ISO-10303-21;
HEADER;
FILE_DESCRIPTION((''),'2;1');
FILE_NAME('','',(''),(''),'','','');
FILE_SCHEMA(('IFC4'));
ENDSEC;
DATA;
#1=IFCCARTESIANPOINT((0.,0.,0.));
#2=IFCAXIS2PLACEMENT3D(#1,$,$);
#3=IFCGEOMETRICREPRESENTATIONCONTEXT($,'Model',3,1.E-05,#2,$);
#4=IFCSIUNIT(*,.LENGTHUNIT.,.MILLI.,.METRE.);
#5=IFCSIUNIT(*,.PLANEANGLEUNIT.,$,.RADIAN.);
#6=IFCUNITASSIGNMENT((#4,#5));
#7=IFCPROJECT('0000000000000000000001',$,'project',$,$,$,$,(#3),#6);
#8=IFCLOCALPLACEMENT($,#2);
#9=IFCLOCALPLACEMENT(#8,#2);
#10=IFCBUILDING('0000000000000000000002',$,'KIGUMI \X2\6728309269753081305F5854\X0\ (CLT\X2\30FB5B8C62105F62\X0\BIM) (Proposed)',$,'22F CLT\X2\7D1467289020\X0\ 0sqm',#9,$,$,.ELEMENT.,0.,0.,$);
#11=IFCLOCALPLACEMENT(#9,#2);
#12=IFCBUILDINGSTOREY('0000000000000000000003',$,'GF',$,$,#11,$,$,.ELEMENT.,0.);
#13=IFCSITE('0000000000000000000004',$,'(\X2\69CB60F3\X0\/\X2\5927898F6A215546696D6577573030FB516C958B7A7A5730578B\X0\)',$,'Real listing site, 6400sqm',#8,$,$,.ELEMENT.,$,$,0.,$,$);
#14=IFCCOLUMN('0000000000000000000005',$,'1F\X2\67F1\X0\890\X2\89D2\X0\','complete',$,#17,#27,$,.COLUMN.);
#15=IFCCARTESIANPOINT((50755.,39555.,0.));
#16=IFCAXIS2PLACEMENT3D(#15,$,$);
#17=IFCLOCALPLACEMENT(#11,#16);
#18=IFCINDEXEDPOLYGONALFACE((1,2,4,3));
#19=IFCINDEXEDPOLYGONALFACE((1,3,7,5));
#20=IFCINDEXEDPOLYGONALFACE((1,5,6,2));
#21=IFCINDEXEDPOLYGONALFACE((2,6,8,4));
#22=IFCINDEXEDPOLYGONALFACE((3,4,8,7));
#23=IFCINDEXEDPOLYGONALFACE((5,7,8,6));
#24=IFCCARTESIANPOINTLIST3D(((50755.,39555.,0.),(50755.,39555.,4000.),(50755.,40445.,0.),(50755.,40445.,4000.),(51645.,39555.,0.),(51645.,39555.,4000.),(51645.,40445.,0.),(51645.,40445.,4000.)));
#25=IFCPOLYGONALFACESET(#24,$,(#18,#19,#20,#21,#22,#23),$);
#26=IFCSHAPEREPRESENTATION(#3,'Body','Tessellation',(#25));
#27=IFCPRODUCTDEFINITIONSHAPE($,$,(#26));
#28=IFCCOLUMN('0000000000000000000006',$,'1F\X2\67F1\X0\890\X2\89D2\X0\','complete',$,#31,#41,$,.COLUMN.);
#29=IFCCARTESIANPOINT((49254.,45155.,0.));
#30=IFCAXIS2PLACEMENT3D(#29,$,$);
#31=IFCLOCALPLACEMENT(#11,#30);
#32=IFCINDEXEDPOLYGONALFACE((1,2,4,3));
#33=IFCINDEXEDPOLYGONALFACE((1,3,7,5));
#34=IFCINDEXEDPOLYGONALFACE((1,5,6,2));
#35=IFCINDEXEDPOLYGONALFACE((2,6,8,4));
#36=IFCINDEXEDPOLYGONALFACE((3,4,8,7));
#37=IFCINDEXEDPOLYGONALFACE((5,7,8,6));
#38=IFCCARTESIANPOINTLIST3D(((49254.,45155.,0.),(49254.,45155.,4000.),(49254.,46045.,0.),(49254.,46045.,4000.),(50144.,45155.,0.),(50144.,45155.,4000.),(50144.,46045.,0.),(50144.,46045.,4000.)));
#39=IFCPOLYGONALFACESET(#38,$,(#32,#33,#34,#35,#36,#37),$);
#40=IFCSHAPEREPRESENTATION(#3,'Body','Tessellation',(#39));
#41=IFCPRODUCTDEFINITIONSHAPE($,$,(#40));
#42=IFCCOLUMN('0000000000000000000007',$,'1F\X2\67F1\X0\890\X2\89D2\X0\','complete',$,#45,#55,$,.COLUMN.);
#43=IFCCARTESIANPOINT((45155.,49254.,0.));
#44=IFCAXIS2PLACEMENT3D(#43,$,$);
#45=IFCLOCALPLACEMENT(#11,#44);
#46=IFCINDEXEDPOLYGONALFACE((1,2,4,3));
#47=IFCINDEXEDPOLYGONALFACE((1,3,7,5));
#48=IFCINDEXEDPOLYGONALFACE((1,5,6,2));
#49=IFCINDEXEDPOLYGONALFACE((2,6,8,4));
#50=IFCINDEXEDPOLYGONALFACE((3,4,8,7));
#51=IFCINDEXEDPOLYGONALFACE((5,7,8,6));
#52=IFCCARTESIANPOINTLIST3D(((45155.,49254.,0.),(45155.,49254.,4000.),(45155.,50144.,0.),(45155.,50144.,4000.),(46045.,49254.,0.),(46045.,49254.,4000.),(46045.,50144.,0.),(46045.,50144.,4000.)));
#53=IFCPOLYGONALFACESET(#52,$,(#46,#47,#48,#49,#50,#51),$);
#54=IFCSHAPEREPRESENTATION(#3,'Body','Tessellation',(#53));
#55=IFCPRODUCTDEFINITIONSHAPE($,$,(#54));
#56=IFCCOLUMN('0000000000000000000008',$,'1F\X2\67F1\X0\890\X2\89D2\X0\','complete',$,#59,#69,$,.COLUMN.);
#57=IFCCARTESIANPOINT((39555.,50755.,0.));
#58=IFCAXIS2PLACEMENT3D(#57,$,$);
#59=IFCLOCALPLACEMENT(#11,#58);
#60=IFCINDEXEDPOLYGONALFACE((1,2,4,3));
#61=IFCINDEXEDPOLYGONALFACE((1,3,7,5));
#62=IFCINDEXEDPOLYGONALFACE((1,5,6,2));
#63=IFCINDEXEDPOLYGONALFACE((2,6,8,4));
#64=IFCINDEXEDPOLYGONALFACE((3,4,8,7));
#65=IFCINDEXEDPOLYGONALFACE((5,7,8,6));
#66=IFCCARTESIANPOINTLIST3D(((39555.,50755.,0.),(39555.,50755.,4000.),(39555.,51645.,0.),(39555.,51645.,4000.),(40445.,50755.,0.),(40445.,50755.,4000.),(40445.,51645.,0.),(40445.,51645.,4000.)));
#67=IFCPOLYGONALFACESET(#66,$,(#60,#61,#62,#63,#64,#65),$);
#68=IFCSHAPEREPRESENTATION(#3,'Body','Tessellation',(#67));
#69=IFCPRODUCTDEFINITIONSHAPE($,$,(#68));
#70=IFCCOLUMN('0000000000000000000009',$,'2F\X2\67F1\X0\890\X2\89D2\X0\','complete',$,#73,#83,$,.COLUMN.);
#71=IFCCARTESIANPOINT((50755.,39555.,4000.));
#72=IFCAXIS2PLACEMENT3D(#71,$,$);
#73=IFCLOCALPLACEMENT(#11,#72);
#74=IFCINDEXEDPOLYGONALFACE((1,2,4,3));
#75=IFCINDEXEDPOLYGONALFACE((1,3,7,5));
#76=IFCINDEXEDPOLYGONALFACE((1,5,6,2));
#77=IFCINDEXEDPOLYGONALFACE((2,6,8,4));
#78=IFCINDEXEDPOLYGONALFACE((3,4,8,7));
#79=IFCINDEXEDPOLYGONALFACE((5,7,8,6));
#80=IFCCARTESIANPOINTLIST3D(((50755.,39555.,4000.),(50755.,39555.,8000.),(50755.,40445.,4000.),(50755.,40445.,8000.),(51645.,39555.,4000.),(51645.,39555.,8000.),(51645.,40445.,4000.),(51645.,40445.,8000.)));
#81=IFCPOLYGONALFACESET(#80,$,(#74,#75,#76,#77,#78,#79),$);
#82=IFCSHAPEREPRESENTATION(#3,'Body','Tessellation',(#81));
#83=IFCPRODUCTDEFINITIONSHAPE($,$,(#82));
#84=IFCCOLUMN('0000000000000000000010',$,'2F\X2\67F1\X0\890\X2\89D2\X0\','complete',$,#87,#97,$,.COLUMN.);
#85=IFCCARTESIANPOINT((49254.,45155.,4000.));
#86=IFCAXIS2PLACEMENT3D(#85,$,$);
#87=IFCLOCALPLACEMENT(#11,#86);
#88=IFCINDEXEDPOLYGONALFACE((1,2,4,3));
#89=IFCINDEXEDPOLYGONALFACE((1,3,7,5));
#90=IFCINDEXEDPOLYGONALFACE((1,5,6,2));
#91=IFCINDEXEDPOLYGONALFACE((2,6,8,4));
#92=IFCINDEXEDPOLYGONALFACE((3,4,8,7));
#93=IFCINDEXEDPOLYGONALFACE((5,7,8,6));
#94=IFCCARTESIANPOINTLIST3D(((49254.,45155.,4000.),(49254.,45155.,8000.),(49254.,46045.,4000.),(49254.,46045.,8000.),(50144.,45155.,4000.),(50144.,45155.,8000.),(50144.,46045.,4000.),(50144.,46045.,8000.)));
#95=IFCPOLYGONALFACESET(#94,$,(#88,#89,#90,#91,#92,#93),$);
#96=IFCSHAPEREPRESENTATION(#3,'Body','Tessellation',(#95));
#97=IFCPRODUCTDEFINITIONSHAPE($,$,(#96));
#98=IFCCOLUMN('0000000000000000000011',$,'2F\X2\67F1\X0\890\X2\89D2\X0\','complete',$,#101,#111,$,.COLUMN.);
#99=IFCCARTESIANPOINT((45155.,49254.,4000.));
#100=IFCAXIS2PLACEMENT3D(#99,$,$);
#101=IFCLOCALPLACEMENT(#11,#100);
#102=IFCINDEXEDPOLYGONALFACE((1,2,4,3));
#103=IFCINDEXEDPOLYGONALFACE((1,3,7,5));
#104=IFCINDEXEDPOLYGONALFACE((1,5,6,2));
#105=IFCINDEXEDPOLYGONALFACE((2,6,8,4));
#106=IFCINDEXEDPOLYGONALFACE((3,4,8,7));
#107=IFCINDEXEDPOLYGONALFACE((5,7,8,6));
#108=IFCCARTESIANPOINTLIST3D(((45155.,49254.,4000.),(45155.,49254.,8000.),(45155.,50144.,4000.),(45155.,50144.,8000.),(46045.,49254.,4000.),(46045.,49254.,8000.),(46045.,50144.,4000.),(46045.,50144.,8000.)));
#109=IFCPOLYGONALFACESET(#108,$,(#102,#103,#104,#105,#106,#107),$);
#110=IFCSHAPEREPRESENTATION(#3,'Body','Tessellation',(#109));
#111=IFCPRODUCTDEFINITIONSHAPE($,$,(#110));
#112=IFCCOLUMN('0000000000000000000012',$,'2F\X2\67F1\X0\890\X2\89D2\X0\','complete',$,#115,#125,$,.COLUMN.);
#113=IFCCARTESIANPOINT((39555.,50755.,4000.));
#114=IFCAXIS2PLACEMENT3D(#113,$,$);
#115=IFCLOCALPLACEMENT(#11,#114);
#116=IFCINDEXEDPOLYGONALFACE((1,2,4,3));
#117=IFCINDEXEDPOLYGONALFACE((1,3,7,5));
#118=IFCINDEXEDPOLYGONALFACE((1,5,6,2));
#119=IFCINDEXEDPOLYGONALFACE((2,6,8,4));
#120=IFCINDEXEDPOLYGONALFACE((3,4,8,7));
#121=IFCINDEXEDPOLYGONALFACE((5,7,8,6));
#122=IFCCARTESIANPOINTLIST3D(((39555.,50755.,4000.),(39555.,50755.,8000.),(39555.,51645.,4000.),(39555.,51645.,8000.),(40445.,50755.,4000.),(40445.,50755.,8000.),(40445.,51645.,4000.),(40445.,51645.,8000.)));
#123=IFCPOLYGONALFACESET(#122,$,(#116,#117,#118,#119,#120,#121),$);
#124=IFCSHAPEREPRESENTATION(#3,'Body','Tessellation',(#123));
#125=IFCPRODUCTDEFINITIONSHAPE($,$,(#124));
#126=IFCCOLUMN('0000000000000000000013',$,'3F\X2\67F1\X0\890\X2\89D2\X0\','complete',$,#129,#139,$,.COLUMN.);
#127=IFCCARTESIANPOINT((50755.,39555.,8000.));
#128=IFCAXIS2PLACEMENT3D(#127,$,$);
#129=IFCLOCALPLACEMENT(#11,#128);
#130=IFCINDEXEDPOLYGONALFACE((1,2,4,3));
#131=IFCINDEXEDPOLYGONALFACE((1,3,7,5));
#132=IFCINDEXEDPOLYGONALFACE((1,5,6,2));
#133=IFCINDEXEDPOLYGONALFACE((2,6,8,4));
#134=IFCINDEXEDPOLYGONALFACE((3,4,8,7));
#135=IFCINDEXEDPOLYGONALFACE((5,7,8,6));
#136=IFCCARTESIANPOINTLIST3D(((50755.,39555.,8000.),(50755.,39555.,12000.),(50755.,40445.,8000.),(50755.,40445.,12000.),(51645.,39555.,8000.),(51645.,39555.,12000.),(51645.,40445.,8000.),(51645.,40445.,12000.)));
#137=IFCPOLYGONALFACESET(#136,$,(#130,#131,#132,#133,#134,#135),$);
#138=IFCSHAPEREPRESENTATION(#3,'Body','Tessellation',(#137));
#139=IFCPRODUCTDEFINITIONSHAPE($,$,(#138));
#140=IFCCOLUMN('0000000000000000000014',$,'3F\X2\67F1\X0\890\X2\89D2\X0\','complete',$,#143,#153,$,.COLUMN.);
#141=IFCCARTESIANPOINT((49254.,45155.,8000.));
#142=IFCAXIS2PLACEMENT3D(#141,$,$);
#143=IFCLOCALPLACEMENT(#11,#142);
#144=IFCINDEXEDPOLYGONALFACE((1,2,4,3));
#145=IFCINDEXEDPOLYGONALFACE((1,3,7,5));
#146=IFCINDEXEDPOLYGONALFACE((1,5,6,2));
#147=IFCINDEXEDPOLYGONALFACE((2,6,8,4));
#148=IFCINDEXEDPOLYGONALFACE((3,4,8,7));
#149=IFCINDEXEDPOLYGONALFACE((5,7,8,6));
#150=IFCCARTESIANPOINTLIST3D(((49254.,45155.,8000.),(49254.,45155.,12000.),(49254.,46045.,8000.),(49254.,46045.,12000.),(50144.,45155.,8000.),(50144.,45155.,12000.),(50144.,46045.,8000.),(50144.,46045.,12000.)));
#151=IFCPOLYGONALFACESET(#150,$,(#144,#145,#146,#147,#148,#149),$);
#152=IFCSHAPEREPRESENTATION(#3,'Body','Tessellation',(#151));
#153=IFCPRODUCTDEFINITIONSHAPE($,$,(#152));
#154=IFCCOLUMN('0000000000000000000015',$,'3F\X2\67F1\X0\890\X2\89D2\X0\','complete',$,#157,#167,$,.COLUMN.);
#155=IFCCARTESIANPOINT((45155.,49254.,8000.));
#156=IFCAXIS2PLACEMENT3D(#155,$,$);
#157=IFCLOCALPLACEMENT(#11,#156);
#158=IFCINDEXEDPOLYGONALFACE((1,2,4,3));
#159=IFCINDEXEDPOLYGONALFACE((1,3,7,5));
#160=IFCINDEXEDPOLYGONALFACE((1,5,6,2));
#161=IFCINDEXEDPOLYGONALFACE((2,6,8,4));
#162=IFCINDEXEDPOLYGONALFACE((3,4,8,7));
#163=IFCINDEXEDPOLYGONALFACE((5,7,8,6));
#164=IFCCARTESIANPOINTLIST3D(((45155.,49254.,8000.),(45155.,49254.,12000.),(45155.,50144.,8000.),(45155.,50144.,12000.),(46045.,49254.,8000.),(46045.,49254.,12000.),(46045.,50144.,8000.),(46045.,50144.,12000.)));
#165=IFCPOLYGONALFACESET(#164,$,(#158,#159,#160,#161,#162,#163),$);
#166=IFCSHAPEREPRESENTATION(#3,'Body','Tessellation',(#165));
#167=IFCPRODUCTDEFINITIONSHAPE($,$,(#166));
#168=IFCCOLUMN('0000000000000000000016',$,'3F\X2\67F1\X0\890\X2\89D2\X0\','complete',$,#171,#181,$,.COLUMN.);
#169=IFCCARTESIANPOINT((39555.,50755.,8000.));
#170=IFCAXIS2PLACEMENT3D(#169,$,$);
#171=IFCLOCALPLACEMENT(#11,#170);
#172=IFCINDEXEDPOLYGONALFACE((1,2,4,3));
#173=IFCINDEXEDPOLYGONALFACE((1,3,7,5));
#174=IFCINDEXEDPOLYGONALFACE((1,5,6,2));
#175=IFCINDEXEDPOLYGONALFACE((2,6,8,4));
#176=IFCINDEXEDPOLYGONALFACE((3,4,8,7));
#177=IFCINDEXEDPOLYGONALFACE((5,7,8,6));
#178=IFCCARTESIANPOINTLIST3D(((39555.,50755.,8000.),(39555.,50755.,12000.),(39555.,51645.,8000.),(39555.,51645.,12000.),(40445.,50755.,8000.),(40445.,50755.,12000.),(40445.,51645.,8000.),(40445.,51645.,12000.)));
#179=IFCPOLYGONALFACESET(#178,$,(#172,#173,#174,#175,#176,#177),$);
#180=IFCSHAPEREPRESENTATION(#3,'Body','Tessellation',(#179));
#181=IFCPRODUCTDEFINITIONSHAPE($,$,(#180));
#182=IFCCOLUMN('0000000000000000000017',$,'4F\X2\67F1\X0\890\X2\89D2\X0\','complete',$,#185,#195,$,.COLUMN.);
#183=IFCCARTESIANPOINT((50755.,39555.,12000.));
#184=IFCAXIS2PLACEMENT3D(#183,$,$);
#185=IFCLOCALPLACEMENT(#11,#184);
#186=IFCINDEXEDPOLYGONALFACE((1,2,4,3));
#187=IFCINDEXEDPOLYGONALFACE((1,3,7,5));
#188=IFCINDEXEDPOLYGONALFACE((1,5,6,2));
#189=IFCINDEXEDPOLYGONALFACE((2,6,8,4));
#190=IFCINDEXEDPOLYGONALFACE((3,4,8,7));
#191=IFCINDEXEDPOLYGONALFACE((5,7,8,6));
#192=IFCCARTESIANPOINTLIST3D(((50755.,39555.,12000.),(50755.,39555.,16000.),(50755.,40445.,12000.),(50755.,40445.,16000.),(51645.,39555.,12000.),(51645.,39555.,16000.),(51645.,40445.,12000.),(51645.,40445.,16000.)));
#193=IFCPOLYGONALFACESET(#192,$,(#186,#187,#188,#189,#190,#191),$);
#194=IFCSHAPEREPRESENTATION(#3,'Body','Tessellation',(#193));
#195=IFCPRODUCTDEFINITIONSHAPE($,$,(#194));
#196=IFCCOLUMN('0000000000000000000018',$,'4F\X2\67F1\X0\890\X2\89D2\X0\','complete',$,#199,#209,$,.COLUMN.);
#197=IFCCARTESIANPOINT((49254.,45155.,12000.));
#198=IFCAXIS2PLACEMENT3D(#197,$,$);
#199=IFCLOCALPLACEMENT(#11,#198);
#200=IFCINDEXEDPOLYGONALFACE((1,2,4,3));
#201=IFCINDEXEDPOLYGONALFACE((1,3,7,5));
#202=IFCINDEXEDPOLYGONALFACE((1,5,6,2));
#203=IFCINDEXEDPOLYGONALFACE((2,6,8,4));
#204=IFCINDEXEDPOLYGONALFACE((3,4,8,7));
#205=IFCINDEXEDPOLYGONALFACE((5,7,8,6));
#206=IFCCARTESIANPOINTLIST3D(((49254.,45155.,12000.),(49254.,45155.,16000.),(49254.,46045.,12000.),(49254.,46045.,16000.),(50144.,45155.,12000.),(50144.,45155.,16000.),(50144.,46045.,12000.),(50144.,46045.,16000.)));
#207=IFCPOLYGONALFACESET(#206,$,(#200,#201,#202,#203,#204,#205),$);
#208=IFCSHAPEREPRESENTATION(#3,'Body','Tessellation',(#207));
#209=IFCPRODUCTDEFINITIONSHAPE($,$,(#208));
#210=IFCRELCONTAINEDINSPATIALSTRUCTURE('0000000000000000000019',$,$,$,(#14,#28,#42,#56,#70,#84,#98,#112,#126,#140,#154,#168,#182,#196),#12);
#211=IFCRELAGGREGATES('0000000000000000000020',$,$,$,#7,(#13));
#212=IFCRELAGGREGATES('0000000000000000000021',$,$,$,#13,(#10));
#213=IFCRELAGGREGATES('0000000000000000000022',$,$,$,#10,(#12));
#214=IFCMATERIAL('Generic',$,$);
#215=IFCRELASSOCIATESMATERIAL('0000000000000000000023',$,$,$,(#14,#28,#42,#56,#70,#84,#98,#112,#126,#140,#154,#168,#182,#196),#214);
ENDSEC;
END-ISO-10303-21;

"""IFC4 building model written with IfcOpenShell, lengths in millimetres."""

from ifc_helpers import new_model, si_unit, frame, frame_2d, origin, place, context, project, spatial, rectangle, extrude, material, element, save


model = new_model("IFC4")

# Units and contexts
model_context = context("Model", 3, precision=1e-05, world=origin())
ifc_project = project(units=[si_unit("LENGTHUNIT", "METRE", prefix="MILLI"), si_unit("PLANEANGLEUNIT", "RADIAN")], contexts=[model_context])

# Site, building, storey
site_placement = place(None, origin())
site = spatial("IfcSite", under=ifc_project, at=site_placement, Name="(構想/大規模商業敷地・公開空地型)", ObjectType="Real listing site, 6400sqm", CompositionType="ELEMENT", RefElevation=0.0)
building_placement = place(site_placement, origin())
building = spatial("IfcBuilding", under=site, at=building_placement, Name="KIGUMI 木を極めた塔 (CLT・完成形BIM) (Proposed)", ObjectType="22F CLT純木造 0sqm", CompositionType="ELEMENT", ElevationOfRefHeight=0.0, ElevationOfTerrain=0.0)
storey_placement = place(building_placement, origin())
storey = spatial("IfcBuildingStorey", under=building, at=storey_placement, Name="GF", CompositionType="ELEMENT", Elevation=0.0)

# Columns
ifc_material = material(Name="Generic")
column_1_placement = place(storey_placement, frame((50755.0, 39555.0, 0.0)))
element("IfcColumn", 1, at=column_1_placement, inside=storey, material=ifc_material, Name="1F柱890角", Description="complete", PredefinedType="COLUMN", context=model_context, shape_type="SweptSolid", body=[
    extrude(rectangle(XDim=890.0, YDim=890.0, at=frame_2d((445.0, 445.0))), frame((50755.0, 39555.0, 0.0)), (0.0, 0.0, 1.0), 4000.0),
])
column_2_placement = place(storey_placement, frame((49254.0, 45155.0, 0.0)))
element("IfcColumn", 2, at=column_2_placement, inside=storey, material=ifc_material, Name="1F柱890角", Description="complete", PredefinedType="COLUMN", context=model_context, shape_type="SweptSolid", body=[
    extrude(rectangle(XDim=890.0, YDim=890.0, at=frame_2d((445.0, 445.0))), frame((49254.0, 45155.0, 0.0)), (0.0, 0.0, 1.0), 4000.0),
])
column_3_placement = place(storey_placement, frame((45155.0, 49254.0, 0.0)))
element("IfcColumn", 3, at=column_3_placement, inside=storey, material=ifc_material, Name="1F柱890角", Description="complete", PredefinedType="COLUMN", context=model_context, shape_type="SweptSolid", body=[
    extrude(rectangle(XDim=890.0, YDim=890.0, at=frame_2d((445.0, 445.0))), frame((45155.0, 49254.0, 0.0)), (0.0, 0.0, 1.0), 4000.0),
])
column_4_placement = place(storey_placement, frame((39555.0, 50755.0, 0.0)))
element("IfcColumn", 4, at=column_4_placement, inside=storey, material=ifc_material, Name="1F柱890角", Description="complete", PredefinedType="COLUMN", context=model_context, shape_type="SweptSolid", body=[
    extrude(rectangle(XDim=890.0, YDim=890.0, at=frame_2d((445.0, 445.0))), frame((39555.0, 50755.0, 0.0)), (0.0, 0.0, 1.0), 4000.0),
])
column_5_placement = place(storey_placement, frame((50755.0, 39555.0, 4000.0)))
element("IfcColumn", 5, at=column_5_placement, inside=storey, material=ifc_material, Name="2F柱890角", Description="complete", PredefinedType="COLUMN", context=model_context, shape_type="SweptSolid", body=[
    extrude(rectangle(XDim=890.0, YDim=890.0, at=frame_2d((445.0, 445.0))), frame((50755.0, 39555.0, 4000.0)), (0.0, 0.0, 1.0), 4000.0),
])
column_6_placement = place(storey_placement, frame((49254.0, 45155.0, 4000.0)))
element("IfcColumn", 6, at=column_6_placement, inside=storey, material=ifc_material, Name="2F柱890角", Description="complete", PredefinedType="COLUMN", context=model_context, shape_type="SweptSolid", body=[
    extrude(rectangle(XDim=890.0, YDim=890.0, at=frame_2d((445.0, 445.0))), frame((49254.0, 45155.0, 4000.0)), (0.0, 0.0, 1.0), 4000.0),
])
column_7_placement = place(storey_placement, frame((45155.0, 49254.0, 4000.0)))
element("IfcColumn", 7, at=column_7_placement, inside=storey, material=ifc_material, Name="2F柱890角", Description="complete", PredefinedType="COLUMN", context=model_context, shape_type="SweptSolid", body=[
    extrude(rectangle(XDim=890.0, YDim=890.0, at=frame_2d((445.0, 445.0))), frame((45155.0, 49254.0, 4000.0)), (0.0, 0.0, 1.0), 4000.0),
])
column_8_placement = place(storey_placement, frame((39555.0, 50755.0, 4000.0)))
element("IfcColumn", 8, at=column_8_placement, inside=storey, material=ifc_material, Name="2F柱890角", Description="complete", PredefinedType="COLUMN", context=model_context, shape_type="SweptSolid", body=[
    extrude(rectangle(XDim=890.0, YDim=890.0, at=frame_2d((445.0, 445.0))), frame((39555.0, 50755.0, 4000.0)), (0.0, 0.0, 1.0), 4000.0),
])
column_9_placement = place(storey_placement, frame((50755.0, 39555.0, 8000.0)))
element("IfcColumn", 9, at=column_9_placement, inside=storey, material=ifc_material, Name="3F柱890角", Description="complete", PredefinedType="COLUMN", context=model_context, shape_type="SweptSolid", body=[
    extrude(rectangle(XDim=890.0, YDim=890.0, at=frame_2d((445.0, 445.0))), frame((50755.0, 39555.0, 8000.0)), (0.0, 0.0, 1.0), 4000.0),
])
column_10_placement = place(storey_placement, frame((49254.0, 45155.0, 8000.0)))
element("IfcColumn", 10, at=column_10_placement, inside=storey, material=ifc_material, Name="3F柱890角", Description="complete", PredefinedType="COLUMN", context=model_context, shape_type="SweptSolid", body=[
    extrude(rectangle(XDim=890.0, YDim=890.0, at=frame_2d((445.0, 445.0))), frame((49254.0, 45155.0, 8000.0)), (0.0, 0.0, 1.0), 4000.0),
])
column_11_placement = place(storey_placement, frame((45155.0, 49254.0, 8000.0)))
element("IfcColumn", 11, at=column_11_placement, inside=storey, material=ifc_material, Name="3F柱890角", Description="complete", PredefinedType="COLUMN", context=model_context, shape_type="SweptSolid", body=[
    extrude(rectangle(XDim=890.0, YDim=890.0, at=frame_2d((445.0, 445.0))), frame((45155.0, 49254.0, 8000.0)), (0.0, 0.0, 1.0), 4000.0),
])
column_12_placement = place(storey_placement, frame((39555.0, 50755.0, 8000.0)))
element("IfcColumn", 12, at=column_12_placement, inside=storey, material=ifc_material, Name="3F柱890角", Description="complete", PredefinedType="COLUMN", context=model_context, shape_type="SweptSolid", body=[
    extrude(rectangle(XDim=890.0, YDim=890.0, at=frame_2d((445.0, 445.0))), frame((39555.0, 50755.0, 8000.0)), (0.0, 0.0, 1.0), 4000.0),
])
column_13_placement = place(storey_placement, frame((50755.0, 39555.0, 12000.0)))
element("IfcColumn", 13, at=column_13_placement, inside=storey, material=ifc_material, Name="4F柱890角", Description="complete", PredefinedType="COLUMN", context=model_context, shape_type="SweptSolid", body=[
    extrude(rectangle(XDim=890.0, YDim=890.0, at=frame_2d((445.0, 445.0))), frame((50755.0, 39555.0, 12000.0)), (0.0, 0.0, 1.0), 4000.0),
])
column_14_placement = place(storey_placement, frame((49254.0, 45155.0, 12000.0)))
element("IfcColumn", 14, at=column_14_placement, inside=storey, material=ifc_material, Name="4F柱890角", Description="complete", PredefinedType="COLUMN", context=model_context, shape_type="SweptSolid", body=[
    extrude(rectangle(XDim=890.0, YDim=890.0, at=frame_2d((445.0, 445.0))), frame((49254.0, 45155.0, 12000.0)), (0.0, 0.0, 1.0), 4000.0),
])

save(model, "model.ifc")
